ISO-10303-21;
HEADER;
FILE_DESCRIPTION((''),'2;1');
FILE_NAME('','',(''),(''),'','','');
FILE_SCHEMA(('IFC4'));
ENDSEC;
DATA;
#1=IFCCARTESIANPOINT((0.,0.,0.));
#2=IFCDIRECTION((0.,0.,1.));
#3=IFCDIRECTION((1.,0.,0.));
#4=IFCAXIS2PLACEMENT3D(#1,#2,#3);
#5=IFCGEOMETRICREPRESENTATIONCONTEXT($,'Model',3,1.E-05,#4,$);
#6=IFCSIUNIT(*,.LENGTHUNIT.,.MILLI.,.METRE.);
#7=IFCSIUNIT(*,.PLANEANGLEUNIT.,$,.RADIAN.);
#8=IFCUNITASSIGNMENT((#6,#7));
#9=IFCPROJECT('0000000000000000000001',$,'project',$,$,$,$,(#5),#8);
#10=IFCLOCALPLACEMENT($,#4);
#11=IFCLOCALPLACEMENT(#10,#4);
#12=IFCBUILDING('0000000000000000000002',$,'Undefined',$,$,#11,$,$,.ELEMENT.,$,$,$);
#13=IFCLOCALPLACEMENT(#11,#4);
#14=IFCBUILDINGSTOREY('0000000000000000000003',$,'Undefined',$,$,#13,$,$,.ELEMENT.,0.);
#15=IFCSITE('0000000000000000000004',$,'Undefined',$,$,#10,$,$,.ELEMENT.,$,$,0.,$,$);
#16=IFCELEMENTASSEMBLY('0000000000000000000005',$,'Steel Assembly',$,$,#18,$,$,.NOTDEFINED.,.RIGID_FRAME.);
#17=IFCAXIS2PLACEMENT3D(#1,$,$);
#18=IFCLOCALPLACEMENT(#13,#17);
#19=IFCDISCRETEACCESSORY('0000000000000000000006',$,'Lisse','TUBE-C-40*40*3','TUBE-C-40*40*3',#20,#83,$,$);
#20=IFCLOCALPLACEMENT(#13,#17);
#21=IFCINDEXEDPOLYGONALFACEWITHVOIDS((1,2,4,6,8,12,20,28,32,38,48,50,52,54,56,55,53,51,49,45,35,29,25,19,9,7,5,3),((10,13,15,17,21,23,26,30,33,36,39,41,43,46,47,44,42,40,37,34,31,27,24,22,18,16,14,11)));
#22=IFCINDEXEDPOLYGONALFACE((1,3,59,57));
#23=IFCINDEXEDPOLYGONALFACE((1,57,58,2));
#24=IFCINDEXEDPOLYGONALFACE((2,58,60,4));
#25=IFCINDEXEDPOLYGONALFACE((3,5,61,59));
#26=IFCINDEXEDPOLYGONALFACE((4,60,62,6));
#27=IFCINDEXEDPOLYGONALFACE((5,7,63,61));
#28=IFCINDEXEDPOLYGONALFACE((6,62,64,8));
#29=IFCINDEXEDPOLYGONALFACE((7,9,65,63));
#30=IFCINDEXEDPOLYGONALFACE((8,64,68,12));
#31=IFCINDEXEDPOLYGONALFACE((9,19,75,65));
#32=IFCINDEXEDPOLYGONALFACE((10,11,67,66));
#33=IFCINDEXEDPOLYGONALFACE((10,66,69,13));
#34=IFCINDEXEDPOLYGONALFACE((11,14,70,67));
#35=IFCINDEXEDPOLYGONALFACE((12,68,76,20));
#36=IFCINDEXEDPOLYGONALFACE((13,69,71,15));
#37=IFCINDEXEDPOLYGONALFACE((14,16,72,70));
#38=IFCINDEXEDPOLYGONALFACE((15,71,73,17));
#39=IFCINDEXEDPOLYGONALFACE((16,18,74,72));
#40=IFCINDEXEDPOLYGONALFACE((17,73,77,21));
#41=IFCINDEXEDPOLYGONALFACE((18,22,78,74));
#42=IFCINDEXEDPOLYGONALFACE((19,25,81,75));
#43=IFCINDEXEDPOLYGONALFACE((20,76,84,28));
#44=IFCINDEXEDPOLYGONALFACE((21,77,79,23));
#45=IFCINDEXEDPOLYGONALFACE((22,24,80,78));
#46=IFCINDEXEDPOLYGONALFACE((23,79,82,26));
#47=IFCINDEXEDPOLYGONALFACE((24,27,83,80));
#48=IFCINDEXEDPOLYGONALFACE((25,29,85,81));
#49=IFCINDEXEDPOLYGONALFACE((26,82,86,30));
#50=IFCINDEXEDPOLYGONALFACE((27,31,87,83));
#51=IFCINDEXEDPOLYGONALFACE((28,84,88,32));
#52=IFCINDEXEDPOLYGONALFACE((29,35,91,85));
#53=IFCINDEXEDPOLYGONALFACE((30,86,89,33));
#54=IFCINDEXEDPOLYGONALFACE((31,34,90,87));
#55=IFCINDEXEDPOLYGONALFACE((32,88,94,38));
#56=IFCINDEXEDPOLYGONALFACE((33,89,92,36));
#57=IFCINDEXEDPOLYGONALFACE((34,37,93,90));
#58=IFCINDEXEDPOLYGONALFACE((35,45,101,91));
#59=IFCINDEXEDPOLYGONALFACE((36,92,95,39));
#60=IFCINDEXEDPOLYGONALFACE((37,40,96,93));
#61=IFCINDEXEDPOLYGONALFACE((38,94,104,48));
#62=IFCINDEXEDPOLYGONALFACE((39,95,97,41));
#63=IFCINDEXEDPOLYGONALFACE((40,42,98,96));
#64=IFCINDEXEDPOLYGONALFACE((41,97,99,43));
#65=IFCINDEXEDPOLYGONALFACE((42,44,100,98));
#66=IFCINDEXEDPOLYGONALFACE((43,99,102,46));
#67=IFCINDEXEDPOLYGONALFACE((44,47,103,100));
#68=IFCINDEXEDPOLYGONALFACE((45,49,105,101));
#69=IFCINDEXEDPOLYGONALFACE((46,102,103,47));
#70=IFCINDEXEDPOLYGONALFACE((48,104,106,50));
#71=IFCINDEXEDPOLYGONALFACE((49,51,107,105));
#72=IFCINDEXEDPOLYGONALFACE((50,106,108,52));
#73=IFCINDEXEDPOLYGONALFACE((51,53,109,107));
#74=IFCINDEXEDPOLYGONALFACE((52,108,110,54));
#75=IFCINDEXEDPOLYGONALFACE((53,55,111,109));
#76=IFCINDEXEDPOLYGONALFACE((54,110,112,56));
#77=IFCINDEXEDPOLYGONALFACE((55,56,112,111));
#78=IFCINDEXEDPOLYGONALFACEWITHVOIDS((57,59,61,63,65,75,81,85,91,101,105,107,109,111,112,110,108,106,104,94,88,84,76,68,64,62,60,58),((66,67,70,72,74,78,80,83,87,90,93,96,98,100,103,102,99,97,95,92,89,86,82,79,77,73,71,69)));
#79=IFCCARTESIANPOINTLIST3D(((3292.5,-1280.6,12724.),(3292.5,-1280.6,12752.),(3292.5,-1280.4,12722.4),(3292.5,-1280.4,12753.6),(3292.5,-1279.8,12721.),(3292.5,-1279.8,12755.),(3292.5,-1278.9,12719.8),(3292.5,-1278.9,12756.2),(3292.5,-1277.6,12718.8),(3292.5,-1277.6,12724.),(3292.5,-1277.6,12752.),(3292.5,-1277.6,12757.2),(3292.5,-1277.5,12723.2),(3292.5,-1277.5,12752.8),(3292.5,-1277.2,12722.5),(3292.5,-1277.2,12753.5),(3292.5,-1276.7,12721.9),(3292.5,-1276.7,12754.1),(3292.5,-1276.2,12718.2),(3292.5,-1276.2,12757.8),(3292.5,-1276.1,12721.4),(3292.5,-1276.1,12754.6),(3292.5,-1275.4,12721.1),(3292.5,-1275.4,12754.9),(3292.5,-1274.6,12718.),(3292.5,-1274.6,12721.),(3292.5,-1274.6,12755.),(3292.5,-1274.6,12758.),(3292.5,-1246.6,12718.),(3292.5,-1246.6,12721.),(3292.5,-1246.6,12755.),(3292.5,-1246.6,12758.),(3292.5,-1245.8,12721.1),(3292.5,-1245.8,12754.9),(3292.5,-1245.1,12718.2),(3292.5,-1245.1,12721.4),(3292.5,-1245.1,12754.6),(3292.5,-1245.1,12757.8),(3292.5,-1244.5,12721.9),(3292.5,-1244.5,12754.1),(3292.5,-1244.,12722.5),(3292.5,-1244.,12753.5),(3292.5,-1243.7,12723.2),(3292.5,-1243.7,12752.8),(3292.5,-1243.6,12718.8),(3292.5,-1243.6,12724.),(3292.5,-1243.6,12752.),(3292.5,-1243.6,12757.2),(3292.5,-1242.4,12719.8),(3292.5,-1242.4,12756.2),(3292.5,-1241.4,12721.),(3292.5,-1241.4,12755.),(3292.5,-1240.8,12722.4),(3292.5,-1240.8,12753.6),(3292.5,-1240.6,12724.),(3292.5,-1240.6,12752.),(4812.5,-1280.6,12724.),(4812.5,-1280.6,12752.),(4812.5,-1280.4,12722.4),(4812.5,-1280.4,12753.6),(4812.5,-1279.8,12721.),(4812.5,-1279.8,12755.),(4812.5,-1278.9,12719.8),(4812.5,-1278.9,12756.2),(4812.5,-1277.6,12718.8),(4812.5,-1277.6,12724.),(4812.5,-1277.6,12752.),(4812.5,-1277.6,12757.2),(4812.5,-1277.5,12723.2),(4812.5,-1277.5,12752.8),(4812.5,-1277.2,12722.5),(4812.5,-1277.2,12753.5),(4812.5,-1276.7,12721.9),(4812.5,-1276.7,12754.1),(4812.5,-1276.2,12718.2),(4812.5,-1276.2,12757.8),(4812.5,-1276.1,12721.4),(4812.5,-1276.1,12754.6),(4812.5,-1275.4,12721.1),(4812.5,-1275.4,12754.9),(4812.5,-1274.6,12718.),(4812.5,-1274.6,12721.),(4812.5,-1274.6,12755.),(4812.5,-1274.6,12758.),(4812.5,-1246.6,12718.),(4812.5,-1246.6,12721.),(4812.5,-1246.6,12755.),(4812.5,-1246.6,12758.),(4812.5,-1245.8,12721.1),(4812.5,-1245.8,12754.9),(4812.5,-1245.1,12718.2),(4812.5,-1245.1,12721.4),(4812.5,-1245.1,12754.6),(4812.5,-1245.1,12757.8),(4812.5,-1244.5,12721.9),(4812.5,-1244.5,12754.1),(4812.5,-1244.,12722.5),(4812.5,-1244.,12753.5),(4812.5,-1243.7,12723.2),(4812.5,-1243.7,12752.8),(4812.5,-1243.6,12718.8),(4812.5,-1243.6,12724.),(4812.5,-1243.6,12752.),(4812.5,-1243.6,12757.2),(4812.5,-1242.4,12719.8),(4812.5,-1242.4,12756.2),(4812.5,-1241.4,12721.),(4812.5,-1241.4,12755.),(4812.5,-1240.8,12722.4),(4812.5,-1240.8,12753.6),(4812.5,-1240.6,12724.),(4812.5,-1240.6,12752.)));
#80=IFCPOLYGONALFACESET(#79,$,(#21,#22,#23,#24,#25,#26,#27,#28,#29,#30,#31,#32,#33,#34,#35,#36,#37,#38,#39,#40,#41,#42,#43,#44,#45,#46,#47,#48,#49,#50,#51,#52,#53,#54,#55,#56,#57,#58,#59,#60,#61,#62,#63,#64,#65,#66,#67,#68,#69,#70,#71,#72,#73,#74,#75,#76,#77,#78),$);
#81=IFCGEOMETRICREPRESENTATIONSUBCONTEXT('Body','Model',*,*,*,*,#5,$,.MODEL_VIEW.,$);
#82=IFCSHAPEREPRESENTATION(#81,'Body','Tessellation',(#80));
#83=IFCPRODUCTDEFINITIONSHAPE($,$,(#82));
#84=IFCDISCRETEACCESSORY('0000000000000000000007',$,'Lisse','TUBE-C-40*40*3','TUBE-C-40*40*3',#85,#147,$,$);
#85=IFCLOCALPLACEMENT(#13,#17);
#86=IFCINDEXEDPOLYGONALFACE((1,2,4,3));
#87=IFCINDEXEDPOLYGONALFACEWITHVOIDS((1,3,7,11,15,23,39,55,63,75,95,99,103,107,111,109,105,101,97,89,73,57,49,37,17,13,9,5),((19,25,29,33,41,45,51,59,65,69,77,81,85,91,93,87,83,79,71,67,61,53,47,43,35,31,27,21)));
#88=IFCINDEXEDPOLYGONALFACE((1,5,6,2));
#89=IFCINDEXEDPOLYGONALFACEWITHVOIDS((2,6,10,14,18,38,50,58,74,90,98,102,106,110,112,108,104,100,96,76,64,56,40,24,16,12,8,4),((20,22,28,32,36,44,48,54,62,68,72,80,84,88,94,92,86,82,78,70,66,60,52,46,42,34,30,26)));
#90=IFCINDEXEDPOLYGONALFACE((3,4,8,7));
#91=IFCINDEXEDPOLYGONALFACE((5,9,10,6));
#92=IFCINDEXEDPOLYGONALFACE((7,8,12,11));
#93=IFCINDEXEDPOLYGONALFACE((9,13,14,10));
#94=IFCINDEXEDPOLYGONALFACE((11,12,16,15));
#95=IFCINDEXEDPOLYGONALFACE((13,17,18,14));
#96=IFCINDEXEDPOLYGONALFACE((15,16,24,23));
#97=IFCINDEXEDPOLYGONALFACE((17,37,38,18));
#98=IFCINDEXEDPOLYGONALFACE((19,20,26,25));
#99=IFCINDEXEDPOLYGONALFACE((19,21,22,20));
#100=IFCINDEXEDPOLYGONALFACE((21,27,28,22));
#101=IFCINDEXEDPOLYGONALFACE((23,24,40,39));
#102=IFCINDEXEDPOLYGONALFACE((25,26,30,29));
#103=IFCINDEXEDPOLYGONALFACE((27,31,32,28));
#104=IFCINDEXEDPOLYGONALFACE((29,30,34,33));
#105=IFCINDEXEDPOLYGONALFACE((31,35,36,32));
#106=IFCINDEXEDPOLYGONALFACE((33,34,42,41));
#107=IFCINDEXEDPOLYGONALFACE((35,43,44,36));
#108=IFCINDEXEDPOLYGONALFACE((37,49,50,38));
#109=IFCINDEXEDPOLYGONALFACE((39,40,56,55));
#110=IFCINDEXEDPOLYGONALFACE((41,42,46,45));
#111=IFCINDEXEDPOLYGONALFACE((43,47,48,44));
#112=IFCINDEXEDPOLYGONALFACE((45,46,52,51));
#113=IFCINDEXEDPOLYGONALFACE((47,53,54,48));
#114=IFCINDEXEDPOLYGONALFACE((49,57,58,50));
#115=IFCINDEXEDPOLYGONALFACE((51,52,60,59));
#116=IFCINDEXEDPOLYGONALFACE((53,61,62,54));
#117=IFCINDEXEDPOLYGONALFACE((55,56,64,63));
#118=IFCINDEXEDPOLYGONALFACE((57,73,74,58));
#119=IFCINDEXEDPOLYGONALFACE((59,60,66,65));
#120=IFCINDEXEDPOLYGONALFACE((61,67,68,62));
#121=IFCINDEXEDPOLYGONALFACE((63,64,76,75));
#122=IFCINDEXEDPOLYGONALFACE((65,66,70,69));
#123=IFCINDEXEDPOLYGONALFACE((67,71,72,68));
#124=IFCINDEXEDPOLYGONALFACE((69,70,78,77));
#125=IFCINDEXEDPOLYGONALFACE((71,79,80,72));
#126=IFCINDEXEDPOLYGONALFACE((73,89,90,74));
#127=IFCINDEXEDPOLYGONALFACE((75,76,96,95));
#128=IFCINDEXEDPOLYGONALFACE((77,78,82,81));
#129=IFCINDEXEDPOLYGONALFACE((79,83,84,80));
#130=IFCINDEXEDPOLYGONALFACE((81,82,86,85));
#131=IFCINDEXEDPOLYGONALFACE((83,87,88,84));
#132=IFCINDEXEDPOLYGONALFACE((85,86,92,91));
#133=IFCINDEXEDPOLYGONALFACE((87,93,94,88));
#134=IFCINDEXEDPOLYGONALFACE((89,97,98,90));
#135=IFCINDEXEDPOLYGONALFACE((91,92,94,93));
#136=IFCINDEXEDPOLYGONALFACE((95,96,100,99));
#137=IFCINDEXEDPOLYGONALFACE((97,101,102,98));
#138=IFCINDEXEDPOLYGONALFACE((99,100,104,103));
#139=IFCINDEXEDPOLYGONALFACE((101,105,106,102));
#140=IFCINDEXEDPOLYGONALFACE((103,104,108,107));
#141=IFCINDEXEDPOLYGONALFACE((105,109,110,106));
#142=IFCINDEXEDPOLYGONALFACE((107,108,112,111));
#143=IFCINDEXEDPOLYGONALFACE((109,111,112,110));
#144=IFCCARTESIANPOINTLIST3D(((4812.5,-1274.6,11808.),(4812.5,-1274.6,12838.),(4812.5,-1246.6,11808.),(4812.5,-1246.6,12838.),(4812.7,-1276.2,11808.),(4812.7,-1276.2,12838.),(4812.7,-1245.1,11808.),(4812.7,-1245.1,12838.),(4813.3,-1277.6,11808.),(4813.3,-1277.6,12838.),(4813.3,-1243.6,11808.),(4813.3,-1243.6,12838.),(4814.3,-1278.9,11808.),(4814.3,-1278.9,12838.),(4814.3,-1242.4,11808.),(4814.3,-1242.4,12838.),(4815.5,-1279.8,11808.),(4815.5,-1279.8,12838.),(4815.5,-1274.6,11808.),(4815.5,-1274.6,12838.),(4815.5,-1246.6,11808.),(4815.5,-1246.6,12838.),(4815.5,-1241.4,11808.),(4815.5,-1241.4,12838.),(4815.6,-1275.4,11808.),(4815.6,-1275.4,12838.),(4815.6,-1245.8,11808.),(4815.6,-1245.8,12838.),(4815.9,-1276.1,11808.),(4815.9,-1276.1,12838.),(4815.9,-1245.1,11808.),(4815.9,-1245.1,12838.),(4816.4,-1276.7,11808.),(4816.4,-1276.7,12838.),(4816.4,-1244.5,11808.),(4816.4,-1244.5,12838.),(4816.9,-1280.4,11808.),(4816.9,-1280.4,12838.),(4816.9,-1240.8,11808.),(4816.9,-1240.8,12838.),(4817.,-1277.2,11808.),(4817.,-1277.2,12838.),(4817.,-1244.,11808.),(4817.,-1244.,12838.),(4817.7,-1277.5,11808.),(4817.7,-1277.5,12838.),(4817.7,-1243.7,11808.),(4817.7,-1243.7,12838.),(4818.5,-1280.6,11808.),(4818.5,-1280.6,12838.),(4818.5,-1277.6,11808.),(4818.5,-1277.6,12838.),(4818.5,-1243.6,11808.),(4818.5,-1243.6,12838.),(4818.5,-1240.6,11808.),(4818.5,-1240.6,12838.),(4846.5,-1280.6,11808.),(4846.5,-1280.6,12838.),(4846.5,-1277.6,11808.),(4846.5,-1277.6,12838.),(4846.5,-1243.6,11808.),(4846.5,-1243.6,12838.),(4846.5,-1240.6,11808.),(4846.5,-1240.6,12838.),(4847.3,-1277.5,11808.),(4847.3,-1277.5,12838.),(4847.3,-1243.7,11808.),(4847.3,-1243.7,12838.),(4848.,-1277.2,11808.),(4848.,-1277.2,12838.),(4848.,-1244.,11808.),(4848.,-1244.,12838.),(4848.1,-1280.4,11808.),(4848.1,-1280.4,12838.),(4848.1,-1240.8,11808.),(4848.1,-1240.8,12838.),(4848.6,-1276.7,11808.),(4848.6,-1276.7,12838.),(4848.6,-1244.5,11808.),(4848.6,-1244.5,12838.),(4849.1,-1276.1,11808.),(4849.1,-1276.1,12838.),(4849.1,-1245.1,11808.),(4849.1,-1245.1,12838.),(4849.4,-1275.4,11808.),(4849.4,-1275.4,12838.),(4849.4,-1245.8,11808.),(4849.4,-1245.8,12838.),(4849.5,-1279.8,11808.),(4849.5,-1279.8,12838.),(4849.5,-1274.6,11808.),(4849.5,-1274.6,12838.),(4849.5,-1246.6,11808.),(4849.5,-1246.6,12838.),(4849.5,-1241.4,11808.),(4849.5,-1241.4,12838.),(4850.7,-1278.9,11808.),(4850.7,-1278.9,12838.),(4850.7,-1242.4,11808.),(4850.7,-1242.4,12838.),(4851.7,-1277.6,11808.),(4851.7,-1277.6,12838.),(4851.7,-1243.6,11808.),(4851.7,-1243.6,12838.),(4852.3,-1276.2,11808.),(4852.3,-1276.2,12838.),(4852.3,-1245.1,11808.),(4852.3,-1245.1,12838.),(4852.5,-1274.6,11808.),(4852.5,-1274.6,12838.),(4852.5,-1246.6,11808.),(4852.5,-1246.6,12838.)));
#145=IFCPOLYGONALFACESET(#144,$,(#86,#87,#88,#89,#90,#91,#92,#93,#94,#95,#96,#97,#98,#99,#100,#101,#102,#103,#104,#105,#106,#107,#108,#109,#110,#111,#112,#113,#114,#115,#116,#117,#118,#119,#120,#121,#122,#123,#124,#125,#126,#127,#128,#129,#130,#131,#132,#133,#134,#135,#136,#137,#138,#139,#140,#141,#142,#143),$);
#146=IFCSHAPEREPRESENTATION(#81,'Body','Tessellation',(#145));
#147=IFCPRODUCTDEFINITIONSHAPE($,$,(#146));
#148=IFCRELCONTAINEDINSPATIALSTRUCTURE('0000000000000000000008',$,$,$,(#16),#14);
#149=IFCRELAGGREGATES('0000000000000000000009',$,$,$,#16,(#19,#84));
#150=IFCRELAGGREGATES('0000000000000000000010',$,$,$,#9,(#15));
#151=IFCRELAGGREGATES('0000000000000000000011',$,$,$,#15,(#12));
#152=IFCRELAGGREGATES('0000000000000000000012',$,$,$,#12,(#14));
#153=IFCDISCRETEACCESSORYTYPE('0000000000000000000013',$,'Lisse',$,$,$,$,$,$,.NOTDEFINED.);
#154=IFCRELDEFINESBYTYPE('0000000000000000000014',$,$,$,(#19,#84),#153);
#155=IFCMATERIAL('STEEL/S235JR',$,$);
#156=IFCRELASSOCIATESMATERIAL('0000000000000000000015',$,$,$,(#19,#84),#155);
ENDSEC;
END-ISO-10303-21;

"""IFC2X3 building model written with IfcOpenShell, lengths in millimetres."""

from ifc_helpers import new_model, si_unit, frame, origin_with_axes, origin_2d_with_axis, place, context, subcontext, project, spatial, hollow_rectangle, extrude, material, type_object, element, aggregate, save


model = new_model("IFC2X3")

# Units and contexts
model_context = context("Model", 3, precision=1e-05, world=origin_with_axes())
body_context = subcontext(model_context, "Body", "Model", "MODEL_VIEW")
ifc_project = project(units=[si_unit("LENGTHUNIT", "METRE", prefix="MILLI"), si_unit("PLANEANGLEUNIT", "RADIAN")], contexts=[model_context])

# Site, building, storey
site_placement = place(None, origin_with_axes())
site = spatial("IfcSite", under=ifc_project, at=site_placement, Name="Undefined", CompositionType="ELEMENT", RefElevation=0.0)
building_placement = place(site_placement, origin_with_axes())
building = spatial("IfcBuilding", under=site, at=building_placement, Name="Undefined", CompositionType="ELEMENT")
storey_placement = place(building_placement, origin_with_axes())
storey = spatial("IfcBuildingStorey", under=building, at=storey_placement, Name="Undefined", CompositionType="ELEMENT", Elevation=0.0)

# Shared definitions
ifc_material_1 = material(Name="STEEL/S235JR")

# Element assembly
assembly_1_placement = place(storey_placement, origin_with_axes())
assembly_1 = element("IfcElementAssembly", 1, at=assembly_1_placement, inside=storey, Name="Steel Assembly", AssemblyPlace="NOTDEFINED", PredefinedType="RIGID_FRAME")

# Discrete accessories
discrete_accessory_type_1 = type_object("IfcDiscreteAccessoryType", Name="Lisse")
discrete_accessory_1_placement = place(assembly_1_placement, frame((4812.5, -1260.6, 12738.0), z_axis=(0.0, 1.0, 0.0), x_axis=(-1.0, 0.0, 0.0)))
discrete_accessory_1 = element("IfcDiscreteAccessory", 2, at=discrete_accessory_1_placement, type_object=discrete_accessory_type_1, material=ifc_material_1, Name="Lisse", Description="TUBE-C-40*40*3", ObjectType="TUBE-C-40*40*3", context=body_context, shape_type="SweptSolid", body=[
    extrude(hollow_rectangle(XDim=40.0, YDim=40.0, WallThickness=3.0, InnerFilletRadius=3.0, OuterFilletRadius=6.0, at=origin_2d_with_axis()), frame((1520.0, 0.0, 0.0), z_axis=(-1.0, 0.0, 0.0), x_axis=(0.0, -1.0, 0.0)), (0.0, 0.0, 1.0), 1520.0),
])
discrete_accessory_2_placement = place(assembly_1_placement, frame((4832.5, -1260.6, 12838.0), z_axis=(0.0, 1.0, 0.0), x_axis=(0.0, 0.0, -1.0)))
discrete_accessory_2 = element("IfcDiscreteAccessory", 3, at=discrete_accessory_2_placement, type_object=discrete_accessory_type_1, material=ifc_material_1, Name="Lisse", Description="TUBE-C-40*40*3", ObjectType="TUBE-C-40*40*3", context=body_context, shape_type="SweptSolid", body=[
    extrude(hollow_rectangle(XDim=40.0, YDim=40.0, WallThickness=3.0, InnerFilletRadius=3.0, OuterFilletRadius=6.0, at=origin_2d_with_axis()), frame((1030.0, 0.0, 0.0), z_axis=(-1.0, 0.0, 0.0), x_axis=(0.0, -1.0, 0.0)), (0.0, 0.0, 1.0), 1030.0),
])
aggregate(assembly_1, [discrete_accessory_1, discrete_accessory_2])

save(model, "model.ifc")
